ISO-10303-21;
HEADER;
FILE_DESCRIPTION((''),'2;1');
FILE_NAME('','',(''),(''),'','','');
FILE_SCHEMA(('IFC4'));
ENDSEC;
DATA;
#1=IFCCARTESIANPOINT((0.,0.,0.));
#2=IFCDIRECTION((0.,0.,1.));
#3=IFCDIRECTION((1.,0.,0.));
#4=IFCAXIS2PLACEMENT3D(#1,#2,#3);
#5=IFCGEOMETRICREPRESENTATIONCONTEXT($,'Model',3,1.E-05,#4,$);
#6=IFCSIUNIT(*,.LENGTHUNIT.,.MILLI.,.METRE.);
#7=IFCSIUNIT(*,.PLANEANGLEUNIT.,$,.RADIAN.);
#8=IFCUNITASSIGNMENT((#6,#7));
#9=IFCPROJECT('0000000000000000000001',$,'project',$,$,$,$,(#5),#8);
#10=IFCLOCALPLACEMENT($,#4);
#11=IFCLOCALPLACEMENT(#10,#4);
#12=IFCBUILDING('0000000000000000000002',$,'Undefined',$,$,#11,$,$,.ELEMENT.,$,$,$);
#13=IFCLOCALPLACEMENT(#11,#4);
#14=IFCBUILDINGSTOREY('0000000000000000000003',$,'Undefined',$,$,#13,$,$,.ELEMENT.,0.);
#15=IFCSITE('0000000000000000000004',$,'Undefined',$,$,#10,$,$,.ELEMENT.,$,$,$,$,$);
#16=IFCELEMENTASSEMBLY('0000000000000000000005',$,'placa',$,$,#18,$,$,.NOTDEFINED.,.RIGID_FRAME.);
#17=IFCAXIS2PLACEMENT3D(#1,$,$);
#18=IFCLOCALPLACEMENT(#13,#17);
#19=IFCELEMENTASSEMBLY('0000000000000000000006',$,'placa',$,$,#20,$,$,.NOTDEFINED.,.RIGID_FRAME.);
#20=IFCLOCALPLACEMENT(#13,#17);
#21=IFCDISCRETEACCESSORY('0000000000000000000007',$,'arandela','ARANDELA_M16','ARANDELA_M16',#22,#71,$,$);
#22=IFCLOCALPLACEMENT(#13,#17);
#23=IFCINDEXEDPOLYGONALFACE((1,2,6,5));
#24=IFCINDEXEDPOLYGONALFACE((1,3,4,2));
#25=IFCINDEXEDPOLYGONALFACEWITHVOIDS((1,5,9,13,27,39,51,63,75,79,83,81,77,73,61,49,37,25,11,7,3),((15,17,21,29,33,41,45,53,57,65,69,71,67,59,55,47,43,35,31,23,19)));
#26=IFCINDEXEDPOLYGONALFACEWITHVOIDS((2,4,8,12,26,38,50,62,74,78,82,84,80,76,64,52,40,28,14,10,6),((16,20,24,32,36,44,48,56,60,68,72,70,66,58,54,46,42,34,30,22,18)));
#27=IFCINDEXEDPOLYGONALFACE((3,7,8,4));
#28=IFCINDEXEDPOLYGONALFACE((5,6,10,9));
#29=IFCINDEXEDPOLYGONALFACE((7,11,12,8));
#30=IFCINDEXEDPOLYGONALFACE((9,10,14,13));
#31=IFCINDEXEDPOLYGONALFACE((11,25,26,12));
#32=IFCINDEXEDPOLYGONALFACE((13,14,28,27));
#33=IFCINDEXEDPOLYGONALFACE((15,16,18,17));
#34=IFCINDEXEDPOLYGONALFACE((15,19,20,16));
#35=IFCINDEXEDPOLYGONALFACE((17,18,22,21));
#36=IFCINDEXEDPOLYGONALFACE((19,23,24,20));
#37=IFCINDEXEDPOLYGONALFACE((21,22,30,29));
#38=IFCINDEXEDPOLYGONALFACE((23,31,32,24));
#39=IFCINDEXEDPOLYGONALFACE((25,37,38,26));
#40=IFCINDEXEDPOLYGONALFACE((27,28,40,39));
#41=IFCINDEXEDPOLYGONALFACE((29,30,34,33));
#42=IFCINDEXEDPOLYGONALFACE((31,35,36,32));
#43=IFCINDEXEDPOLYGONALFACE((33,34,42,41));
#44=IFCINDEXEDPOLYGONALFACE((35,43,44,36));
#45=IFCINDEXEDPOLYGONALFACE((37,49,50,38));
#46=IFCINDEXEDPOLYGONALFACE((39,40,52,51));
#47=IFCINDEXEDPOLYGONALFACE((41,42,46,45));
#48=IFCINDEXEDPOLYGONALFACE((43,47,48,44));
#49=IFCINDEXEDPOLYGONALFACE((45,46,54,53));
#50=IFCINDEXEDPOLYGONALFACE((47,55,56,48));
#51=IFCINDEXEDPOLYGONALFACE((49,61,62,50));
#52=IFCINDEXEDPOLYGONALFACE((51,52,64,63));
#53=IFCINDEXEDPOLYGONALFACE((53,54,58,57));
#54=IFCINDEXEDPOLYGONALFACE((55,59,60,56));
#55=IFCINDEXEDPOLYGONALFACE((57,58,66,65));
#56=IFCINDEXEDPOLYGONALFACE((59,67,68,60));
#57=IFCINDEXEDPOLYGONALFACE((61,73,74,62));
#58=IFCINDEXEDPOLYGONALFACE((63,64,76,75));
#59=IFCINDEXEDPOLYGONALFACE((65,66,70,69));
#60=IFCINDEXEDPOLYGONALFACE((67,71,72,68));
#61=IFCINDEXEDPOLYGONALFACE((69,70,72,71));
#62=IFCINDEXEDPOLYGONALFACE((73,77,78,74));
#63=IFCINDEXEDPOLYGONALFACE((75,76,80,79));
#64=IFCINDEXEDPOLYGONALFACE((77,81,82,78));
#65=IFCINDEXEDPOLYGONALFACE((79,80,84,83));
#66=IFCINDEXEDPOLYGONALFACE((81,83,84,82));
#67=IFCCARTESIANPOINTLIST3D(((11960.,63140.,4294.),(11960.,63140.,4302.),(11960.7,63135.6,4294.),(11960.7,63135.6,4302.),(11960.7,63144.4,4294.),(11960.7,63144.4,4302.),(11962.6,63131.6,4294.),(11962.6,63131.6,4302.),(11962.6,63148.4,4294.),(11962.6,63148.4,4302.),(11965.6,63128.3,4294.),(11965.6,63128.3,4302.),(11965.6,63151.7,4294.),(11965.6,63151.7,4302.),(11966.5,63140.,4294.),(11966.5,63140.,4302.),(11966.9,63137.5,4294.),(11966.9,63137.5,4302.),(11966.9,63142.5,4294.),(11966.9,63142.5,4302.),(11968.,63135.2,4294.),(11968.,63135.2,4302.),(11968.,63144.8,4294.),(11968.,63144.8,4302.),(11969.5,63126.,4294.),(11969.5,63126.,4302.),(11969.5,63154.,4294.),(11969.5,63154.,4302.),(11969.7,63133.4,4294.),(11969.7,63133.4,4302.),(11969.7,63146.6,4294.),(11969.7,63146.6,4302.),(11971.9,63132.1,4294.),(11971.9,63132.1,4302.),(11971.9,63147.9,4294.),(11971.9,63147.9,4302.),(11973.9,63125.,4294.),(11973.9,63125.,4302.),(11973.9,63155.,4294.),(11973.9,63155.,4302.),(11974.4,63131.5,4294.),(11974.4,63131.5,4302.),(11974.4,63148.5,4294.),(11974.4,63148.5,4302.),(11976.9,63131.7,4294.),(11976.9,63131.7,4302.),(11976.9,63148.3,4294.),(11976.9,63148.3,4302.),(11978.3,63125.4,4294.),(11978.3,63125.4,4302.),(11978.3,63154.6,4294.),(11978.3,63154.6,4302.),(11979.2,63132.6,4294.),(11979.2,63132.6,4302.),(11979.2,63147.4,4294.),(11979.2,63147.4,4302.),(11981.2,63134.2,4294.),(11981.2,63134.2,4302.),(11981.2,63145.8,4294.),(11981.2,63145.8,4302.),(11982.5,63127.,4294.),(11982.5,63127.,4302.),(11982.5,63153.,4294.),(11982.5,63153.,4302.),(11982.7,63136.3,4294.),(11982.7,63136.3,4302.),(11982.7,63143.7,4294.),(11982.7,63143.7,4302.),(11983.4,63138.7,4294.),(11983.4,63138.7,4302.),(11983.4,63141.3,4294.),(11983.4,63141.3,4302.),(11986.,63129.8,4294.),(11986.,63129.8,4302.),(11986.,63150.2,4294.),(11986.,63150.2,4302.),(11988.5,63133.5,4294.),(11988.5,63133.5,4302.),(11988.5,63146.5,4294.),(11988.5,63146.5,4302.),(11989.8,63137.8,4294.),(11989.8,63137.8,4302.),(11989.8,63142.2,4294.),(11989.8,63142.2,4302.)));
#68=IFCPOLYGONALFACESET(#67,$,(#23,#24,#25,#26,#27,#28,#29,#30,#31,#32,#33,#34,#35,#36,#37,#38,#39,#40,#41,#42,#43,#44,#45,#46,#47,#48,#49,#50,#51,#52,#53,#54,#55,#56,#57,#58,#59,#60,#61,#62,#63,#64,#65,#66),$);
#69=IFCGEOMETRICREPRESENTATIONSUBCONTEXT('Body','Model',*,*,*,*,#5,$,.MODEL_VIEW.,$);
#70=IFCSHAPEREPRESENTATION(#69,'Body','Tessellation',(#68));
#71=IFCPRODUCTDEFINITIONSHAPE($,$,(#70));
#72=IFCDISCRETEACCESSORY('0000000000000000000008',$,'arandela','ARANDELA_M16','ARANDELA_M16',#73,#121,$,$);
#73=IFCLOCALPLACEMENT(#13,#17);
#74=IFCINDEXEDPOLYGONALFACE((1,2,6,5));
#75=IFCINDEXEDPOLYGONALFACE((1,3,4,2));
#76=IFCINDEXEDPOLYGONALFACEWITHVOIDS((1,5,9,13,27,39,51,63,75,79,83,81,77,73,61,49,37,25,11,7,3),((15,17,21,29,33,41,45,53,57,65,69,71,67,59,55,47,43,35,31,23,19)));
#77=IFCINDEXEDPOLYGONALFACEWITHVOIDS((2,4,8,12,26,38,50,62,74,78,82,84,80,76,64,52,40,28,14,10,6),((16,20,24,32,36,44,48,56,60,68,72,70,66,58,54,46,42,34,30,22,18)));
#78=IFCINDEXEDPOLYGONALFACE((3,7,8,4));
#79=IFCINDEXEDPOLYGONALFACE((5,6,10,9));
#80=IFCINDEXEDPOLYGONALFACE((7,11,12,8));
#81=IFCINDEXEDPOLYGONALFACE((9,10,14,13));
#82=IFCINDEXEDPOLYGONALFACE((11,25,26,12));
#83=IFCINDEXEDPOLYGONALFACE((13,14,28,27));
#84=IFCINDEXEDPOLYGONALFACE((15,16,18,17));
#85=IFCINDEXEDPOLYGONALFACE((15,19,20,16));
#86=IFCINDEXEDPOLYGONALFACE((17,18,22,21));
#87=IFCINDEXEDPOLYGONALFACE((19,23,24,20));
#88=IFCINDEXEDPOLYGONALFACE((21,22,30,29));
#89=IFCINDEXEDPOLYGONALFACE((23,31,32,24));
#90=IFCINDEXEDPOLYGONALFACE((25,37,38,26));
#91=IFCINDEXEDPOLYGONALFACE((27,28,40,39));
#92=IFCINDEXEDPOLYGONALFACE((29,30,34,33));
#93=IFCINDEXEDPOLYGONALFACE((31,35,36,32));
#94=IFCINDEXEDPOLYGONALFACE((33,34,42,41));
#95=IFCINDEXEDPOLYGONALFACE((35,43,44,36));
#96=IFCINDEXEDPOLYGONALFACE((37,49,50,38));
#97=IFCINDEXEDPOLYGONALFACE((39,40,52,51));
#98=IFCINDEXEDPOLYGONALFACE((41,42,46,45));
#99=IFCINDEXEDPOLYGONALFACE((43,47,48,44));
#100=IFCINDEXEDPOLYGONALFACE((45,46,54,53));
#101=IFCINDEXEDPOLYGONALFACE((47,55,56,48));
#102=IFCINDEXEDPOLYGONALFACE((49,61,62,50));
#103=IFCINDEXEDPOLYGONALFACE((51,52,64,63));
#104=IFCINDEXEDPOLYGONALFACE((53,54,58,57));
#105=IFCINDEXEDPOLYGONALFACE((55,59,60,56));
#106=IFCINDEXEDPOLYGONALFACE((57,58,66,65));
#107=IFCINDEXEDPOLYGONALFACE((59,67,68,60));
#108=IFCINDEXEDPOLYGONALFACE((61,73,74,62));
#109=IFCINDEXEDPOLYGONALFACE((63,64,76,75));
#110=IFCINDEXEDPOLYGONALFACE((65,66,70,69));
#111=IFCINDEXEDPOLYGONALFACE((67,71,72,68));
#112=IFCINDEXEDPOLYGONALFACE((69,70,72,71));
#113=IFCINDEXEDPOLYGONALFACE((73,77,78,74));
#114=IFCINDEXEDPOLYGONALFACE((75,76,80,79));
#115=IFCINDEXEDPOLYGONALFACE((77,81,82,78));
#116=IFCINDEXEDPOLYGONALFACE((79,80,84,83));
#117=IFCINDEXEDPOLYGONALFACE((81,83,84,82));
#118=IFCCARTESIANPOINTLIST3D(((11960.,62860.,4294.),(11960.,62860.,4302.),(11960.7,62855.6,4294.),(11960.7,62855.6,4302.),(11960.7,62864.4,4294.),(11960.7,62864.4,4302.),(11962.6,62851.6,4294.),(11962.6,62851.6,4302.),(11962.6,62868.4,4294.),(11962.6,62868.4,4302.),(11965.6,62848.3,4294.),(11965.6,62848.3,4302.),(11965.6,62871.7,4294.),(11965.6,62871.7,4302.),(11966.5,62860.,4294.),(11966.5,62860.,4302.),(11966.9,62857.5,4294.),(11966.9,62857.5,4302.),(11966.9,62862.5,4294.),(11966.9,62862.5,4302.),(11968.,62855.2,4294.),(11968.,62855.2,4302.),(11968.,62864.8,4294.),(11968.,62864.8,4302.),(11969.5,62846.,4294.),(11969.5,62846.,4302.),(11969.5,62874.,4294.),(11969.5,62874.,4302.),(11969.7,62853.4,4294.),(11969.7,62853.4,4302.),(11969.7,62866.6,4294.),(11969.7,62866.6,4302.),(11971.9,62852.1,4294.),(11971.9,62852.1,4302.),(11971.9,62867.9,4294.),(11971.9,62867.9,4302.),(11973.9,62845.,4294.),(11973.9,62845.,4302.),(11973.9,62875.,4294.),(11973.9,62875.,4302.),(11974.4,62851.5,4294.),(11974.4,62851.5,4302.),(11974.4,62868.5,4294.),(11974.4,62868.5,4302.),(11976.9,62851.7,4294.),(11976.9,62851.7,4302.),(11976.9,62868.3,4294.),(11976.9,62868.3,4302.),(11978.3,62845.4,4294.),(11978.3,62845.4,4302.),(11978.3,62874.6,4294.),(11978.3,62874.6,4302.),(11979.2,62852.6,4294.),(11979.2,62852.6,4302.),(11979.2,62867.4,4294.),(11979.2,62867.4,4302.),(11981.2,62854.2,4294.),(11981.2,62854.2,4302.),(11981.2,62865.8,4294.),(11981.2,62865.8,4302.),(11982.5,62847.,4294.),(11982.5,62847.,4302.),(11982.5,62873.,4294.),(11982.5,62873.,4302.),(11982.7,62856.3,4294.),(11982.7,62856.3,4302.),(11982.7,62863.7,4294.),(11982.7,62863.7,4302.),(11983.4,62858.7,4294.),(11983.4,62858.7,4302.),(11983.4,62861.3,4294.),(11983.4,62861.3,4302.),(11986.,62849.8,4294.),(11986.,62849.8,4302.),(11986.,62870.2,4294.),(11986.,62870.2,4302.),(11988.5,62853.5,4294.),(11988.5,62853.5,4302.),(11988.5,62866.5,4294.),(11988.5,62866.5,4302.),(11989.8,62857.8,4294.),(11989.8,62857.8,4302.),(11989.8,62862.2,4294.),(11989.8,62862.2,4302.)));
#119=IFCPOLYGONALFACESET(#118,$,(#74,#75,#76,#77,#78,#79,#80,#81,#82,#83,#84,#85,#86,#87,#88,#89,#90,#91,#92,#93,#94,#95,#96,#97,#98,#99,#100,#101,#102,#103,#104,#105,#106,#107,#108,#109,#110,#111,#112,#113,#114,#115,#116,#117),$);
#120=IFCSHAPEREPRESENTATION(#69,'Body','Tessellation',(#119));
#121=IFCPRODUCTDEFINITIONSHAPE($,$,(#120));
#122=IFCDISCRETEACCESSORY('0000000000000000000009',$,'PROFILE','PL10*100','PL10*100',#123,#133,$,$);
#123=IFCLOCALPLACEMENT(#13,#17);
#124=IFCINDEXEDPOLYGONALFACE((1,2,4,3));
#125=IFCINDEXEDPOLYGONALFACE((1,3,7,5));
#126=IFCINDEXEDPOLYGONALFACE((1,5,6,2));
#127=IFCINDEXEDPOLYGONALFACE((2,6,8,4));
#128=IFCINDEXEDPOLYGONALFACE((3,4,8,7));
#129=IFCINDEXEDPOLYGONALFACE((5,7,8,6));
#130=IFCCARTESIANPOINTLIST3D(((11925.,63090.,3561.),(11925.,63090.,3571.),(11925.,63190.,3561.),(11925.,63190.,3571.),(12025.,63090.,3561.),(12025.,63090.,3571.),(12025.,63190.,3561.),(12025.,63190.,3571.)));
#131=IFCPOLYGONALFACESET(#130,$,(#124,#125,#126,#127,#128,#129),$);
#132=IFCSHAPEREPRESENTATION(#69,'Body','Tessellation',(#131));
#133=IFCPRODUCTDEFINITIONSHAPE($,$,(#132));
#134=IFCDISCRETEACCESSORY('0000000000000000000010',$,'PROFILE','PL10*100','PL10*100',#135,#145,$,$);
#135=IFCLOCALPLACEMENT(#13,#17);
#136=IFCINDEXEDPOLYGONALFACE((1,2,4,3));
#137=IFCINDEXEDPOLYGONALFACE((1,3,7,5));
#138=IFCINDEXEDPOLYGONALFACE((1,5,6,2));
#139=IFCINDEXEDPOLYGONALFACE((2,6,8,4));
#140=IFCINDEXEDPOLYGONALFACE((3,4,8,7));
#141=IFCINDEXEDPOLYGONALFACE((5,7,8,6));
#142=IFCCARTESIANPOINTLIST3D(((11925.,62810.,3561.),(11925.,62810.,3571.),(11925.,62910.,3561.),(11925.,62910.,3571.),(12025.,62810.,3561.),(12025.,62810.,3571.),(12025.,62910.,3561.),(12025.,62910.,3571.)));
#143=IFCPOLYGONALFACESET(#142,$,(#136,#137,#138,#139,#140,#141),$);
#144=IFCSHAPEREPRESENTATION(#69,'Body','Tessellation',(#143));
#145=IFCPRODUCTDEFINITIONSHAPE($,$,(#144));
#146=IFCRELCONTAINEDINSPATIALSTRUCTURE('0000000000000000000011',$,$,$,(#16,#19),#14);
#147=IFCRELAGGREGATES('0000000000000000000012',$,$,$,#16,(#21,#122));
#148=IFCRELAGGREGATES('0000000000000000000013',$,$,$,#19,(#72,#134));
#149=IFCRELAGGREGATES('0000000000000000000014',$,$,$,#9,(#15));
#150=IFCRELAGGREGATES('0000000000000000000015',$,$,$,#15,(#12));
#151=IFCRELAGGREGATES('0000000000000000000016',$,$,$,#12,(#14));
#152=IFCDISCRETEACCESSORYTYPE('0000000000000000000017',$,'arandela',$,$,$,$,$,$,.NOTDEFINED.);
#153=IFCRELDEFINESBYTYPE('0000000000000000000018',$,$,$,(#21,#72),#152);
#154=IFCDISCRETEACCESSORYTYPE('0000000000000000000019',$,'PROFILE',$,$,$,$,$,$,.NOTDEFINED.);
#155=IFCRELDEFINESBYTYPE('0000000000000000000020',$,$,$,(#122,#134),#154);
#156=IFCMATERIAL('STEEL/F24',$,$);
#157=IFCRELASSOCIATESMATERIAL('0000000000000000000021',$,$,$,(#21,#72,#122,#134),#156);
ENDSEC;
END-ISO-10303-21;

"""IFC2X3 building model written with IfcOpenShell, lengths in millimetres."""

from ifc_helpers import new_model, si_unit, frame, origin_with_axes, origin_2d_with_axis, place, context, subcontext, project, spatial, polyline, hollow_circle, outline, extrude, material, type_object, element, aggregate, save


model = new_model("IFC2X3")

# Units and contexts
model_context = context("Model", 3, precision=1e-05, world=origin_with_axes())
body_context = subcontext(model_context, "Body", "Model", "MODEL_VIEW")
ifc_project = project(units=[si_unit("LENGTHUNIT", "METRE", prefix="MILLI"), si_unit("PLANEANGLEUNIT", "RADIAN")], contexts=[model_context])

# Site, building, storey
site_placement = place(None, origin_with_axes())
site = spatial("IfcSite", under=ifc_project, at=site_placement, Name="Undefined", CompositionType="ELEMENT")
building_placement = place(site_placement, origin_with_axes())
building = spatial("IfcBuilding", under=site, at=building_placement, Name="Undefined", CompositionType="ELEMENT")
storey_placement = place(building_placement, origin_with_axes())
storey = spatial("IfcBuildingStorey", under=building, at=storey_placement, Name="Undefined", CompositionType="ELEMENT", Elevation=0.0)

# Shared definitions
ifc_material_1 = material(Name="STEEL/F24")

# Element assemblies
assembly_1_placement = place(storey_placement, origin_with_axes())
assembly_1 = element("IfcElementAssembly", 1, at=assembly_1_placement, inside=storey, Name="placa", AssemblyPlace="NOTDEFINED", PredefinedType="RIGID_FRAME")
assembly_2_placement = place(storey_placement, origin_with_axes())
assembly_2 = element("IfcElementAssembly", 2, at=assembly_2_placement, inside=storey, Name="placa", AssemblyPlace="NOTDEFINED", PredefinedType="RIGID_FRAME")

# Discrete accessories
discrete_accessory_type_1 = type_object("IfcDiscreteAccessoryType", Name="arandela")
discrete_accessory_1_placement = place(assembly_1_placement, frame((11975.0, 63140.0, 4302.1), z_axis=(0.0, 0.0, -1.0), x_axis=(0.0, -1.0, 0.0)))
discrete_accessory_1 = element("IfcDiscreteAccessory", 3, at=discrete_accessory_1_placement, type_object=discrete_accessory_type_1, material=ifc_material_1, Name="arandela", Description="ARANDELA_M16", ObjectType="ARANDELA_M16", context=body_context, shape_type="SweptSolid", body=[
    extrude(hollow_circle(Radius=15.0, WallThickness=6.5, at=origin_2d_with_axis()), frame((0.0, 0.0, 8.0), z_axis=(0.0, 0.0, -1.0), x_axis=(0.0, 1.0, 0.0)), (0.0, 0.0, 1.0), 8.0),
])
discrete_accessory_2_placement = place(assembly_2_placement, frame((11975.0, 62860.0, 4302.1), z_axis=(0.0, 0.0, -1.0), x_axis=(0.0, -1.0, 0.0)))
discrete_accessory_2 = element("IfcDiscreteAccessory", 4, at=discrete_accessory_2_placement, type_object=discrete_accessory_type_1, material=ifc_material_1, Name="arandela", Description="ARANDELA_M16", ObjectType="ARANDELA_M16", context=body_context, shape_type="SweptSolid", body=[
    extrude(hollow_circle(Radius=15.0, WallThickness=6.5, at=origin_2d_with_axis()), frame((0.0, 0.0, 8.0), z_axis=(0.0, 0.0, -1.0), x_axis=(0.0, 1.0, 0.0)), (0.0, 0.0, 1.0), 8.0),
])
discrete_accessory_type_2 = type_object("IfcDiscreteAccessoryType", Name="PROFILE")
discrete_accessory_3_placement = place(assembly_1_placement, frame((11975.0, 63190.0, 3566.1), z_axis=(0.0, 0.0, -1.0), x_axis=(0.0, -1.0, 0.0)))
discrete_accessory_3 = element("IfcDiscreteAccessory", 5, at=discrete_accessory_3_placement, type_object=discrete_accessory_type_2, material=ifc_material_1, Name="PROFILE", Description="PL10*100", ObjectType="PL10*100", context=body_context, shape_type="SweptSolid", body=[
    extrude(outline(polyline([(100.0, 50.0), (100.0, -50.0), (0.0, -50.0), (0.0, 50.0), (100.0, 50.0)])), frame((0.0, 0.0, -5.0), z_axis=(0.0, 0.0, 1.0), x_axis=(1.0, 0.0, 0.0)), (0.0, 0.0, 1.0), 10.0),
])
aggregate(assembly_1, [discrete_accessory_1, discrete_accessory_3])
discrete_accessory_4_placement = place(assembly_2_placement, frame((11975.0, 62910.0, 3566.1), z_axis=(0.0, 0.0, -1.0), x_axis=(0.0, -1.0, 0.0)))
discrete_accessory_4 = element("IfcDiscreteAccessory", 6, at=discrete_accessory_4_placement, type_object=discrete_accessory_type_2, material=ifc_material_1, Name="PROFILE", Description="PL10*100", ObjectType="PL10*100", context=body_context, shape_type="SweptSolid", body=[
    extrude(outline(polyline([(100.0, 50.0), (100.0, -50.0), (0.0, -50.0), (0.0, 50.0), (100.0, 50.0)])), frame((0.0, 0.0, -5.0), z_axis=(0.0, 0.0, 1.0), x_axis=(1.0, 0.0, 0.0)), (0.0, 0.0, 1.0), 10.0),
])
aggregate(assembly_2, [discrete_accessory_2, discrete_accessory_4])

save(model, "model.ifc")
